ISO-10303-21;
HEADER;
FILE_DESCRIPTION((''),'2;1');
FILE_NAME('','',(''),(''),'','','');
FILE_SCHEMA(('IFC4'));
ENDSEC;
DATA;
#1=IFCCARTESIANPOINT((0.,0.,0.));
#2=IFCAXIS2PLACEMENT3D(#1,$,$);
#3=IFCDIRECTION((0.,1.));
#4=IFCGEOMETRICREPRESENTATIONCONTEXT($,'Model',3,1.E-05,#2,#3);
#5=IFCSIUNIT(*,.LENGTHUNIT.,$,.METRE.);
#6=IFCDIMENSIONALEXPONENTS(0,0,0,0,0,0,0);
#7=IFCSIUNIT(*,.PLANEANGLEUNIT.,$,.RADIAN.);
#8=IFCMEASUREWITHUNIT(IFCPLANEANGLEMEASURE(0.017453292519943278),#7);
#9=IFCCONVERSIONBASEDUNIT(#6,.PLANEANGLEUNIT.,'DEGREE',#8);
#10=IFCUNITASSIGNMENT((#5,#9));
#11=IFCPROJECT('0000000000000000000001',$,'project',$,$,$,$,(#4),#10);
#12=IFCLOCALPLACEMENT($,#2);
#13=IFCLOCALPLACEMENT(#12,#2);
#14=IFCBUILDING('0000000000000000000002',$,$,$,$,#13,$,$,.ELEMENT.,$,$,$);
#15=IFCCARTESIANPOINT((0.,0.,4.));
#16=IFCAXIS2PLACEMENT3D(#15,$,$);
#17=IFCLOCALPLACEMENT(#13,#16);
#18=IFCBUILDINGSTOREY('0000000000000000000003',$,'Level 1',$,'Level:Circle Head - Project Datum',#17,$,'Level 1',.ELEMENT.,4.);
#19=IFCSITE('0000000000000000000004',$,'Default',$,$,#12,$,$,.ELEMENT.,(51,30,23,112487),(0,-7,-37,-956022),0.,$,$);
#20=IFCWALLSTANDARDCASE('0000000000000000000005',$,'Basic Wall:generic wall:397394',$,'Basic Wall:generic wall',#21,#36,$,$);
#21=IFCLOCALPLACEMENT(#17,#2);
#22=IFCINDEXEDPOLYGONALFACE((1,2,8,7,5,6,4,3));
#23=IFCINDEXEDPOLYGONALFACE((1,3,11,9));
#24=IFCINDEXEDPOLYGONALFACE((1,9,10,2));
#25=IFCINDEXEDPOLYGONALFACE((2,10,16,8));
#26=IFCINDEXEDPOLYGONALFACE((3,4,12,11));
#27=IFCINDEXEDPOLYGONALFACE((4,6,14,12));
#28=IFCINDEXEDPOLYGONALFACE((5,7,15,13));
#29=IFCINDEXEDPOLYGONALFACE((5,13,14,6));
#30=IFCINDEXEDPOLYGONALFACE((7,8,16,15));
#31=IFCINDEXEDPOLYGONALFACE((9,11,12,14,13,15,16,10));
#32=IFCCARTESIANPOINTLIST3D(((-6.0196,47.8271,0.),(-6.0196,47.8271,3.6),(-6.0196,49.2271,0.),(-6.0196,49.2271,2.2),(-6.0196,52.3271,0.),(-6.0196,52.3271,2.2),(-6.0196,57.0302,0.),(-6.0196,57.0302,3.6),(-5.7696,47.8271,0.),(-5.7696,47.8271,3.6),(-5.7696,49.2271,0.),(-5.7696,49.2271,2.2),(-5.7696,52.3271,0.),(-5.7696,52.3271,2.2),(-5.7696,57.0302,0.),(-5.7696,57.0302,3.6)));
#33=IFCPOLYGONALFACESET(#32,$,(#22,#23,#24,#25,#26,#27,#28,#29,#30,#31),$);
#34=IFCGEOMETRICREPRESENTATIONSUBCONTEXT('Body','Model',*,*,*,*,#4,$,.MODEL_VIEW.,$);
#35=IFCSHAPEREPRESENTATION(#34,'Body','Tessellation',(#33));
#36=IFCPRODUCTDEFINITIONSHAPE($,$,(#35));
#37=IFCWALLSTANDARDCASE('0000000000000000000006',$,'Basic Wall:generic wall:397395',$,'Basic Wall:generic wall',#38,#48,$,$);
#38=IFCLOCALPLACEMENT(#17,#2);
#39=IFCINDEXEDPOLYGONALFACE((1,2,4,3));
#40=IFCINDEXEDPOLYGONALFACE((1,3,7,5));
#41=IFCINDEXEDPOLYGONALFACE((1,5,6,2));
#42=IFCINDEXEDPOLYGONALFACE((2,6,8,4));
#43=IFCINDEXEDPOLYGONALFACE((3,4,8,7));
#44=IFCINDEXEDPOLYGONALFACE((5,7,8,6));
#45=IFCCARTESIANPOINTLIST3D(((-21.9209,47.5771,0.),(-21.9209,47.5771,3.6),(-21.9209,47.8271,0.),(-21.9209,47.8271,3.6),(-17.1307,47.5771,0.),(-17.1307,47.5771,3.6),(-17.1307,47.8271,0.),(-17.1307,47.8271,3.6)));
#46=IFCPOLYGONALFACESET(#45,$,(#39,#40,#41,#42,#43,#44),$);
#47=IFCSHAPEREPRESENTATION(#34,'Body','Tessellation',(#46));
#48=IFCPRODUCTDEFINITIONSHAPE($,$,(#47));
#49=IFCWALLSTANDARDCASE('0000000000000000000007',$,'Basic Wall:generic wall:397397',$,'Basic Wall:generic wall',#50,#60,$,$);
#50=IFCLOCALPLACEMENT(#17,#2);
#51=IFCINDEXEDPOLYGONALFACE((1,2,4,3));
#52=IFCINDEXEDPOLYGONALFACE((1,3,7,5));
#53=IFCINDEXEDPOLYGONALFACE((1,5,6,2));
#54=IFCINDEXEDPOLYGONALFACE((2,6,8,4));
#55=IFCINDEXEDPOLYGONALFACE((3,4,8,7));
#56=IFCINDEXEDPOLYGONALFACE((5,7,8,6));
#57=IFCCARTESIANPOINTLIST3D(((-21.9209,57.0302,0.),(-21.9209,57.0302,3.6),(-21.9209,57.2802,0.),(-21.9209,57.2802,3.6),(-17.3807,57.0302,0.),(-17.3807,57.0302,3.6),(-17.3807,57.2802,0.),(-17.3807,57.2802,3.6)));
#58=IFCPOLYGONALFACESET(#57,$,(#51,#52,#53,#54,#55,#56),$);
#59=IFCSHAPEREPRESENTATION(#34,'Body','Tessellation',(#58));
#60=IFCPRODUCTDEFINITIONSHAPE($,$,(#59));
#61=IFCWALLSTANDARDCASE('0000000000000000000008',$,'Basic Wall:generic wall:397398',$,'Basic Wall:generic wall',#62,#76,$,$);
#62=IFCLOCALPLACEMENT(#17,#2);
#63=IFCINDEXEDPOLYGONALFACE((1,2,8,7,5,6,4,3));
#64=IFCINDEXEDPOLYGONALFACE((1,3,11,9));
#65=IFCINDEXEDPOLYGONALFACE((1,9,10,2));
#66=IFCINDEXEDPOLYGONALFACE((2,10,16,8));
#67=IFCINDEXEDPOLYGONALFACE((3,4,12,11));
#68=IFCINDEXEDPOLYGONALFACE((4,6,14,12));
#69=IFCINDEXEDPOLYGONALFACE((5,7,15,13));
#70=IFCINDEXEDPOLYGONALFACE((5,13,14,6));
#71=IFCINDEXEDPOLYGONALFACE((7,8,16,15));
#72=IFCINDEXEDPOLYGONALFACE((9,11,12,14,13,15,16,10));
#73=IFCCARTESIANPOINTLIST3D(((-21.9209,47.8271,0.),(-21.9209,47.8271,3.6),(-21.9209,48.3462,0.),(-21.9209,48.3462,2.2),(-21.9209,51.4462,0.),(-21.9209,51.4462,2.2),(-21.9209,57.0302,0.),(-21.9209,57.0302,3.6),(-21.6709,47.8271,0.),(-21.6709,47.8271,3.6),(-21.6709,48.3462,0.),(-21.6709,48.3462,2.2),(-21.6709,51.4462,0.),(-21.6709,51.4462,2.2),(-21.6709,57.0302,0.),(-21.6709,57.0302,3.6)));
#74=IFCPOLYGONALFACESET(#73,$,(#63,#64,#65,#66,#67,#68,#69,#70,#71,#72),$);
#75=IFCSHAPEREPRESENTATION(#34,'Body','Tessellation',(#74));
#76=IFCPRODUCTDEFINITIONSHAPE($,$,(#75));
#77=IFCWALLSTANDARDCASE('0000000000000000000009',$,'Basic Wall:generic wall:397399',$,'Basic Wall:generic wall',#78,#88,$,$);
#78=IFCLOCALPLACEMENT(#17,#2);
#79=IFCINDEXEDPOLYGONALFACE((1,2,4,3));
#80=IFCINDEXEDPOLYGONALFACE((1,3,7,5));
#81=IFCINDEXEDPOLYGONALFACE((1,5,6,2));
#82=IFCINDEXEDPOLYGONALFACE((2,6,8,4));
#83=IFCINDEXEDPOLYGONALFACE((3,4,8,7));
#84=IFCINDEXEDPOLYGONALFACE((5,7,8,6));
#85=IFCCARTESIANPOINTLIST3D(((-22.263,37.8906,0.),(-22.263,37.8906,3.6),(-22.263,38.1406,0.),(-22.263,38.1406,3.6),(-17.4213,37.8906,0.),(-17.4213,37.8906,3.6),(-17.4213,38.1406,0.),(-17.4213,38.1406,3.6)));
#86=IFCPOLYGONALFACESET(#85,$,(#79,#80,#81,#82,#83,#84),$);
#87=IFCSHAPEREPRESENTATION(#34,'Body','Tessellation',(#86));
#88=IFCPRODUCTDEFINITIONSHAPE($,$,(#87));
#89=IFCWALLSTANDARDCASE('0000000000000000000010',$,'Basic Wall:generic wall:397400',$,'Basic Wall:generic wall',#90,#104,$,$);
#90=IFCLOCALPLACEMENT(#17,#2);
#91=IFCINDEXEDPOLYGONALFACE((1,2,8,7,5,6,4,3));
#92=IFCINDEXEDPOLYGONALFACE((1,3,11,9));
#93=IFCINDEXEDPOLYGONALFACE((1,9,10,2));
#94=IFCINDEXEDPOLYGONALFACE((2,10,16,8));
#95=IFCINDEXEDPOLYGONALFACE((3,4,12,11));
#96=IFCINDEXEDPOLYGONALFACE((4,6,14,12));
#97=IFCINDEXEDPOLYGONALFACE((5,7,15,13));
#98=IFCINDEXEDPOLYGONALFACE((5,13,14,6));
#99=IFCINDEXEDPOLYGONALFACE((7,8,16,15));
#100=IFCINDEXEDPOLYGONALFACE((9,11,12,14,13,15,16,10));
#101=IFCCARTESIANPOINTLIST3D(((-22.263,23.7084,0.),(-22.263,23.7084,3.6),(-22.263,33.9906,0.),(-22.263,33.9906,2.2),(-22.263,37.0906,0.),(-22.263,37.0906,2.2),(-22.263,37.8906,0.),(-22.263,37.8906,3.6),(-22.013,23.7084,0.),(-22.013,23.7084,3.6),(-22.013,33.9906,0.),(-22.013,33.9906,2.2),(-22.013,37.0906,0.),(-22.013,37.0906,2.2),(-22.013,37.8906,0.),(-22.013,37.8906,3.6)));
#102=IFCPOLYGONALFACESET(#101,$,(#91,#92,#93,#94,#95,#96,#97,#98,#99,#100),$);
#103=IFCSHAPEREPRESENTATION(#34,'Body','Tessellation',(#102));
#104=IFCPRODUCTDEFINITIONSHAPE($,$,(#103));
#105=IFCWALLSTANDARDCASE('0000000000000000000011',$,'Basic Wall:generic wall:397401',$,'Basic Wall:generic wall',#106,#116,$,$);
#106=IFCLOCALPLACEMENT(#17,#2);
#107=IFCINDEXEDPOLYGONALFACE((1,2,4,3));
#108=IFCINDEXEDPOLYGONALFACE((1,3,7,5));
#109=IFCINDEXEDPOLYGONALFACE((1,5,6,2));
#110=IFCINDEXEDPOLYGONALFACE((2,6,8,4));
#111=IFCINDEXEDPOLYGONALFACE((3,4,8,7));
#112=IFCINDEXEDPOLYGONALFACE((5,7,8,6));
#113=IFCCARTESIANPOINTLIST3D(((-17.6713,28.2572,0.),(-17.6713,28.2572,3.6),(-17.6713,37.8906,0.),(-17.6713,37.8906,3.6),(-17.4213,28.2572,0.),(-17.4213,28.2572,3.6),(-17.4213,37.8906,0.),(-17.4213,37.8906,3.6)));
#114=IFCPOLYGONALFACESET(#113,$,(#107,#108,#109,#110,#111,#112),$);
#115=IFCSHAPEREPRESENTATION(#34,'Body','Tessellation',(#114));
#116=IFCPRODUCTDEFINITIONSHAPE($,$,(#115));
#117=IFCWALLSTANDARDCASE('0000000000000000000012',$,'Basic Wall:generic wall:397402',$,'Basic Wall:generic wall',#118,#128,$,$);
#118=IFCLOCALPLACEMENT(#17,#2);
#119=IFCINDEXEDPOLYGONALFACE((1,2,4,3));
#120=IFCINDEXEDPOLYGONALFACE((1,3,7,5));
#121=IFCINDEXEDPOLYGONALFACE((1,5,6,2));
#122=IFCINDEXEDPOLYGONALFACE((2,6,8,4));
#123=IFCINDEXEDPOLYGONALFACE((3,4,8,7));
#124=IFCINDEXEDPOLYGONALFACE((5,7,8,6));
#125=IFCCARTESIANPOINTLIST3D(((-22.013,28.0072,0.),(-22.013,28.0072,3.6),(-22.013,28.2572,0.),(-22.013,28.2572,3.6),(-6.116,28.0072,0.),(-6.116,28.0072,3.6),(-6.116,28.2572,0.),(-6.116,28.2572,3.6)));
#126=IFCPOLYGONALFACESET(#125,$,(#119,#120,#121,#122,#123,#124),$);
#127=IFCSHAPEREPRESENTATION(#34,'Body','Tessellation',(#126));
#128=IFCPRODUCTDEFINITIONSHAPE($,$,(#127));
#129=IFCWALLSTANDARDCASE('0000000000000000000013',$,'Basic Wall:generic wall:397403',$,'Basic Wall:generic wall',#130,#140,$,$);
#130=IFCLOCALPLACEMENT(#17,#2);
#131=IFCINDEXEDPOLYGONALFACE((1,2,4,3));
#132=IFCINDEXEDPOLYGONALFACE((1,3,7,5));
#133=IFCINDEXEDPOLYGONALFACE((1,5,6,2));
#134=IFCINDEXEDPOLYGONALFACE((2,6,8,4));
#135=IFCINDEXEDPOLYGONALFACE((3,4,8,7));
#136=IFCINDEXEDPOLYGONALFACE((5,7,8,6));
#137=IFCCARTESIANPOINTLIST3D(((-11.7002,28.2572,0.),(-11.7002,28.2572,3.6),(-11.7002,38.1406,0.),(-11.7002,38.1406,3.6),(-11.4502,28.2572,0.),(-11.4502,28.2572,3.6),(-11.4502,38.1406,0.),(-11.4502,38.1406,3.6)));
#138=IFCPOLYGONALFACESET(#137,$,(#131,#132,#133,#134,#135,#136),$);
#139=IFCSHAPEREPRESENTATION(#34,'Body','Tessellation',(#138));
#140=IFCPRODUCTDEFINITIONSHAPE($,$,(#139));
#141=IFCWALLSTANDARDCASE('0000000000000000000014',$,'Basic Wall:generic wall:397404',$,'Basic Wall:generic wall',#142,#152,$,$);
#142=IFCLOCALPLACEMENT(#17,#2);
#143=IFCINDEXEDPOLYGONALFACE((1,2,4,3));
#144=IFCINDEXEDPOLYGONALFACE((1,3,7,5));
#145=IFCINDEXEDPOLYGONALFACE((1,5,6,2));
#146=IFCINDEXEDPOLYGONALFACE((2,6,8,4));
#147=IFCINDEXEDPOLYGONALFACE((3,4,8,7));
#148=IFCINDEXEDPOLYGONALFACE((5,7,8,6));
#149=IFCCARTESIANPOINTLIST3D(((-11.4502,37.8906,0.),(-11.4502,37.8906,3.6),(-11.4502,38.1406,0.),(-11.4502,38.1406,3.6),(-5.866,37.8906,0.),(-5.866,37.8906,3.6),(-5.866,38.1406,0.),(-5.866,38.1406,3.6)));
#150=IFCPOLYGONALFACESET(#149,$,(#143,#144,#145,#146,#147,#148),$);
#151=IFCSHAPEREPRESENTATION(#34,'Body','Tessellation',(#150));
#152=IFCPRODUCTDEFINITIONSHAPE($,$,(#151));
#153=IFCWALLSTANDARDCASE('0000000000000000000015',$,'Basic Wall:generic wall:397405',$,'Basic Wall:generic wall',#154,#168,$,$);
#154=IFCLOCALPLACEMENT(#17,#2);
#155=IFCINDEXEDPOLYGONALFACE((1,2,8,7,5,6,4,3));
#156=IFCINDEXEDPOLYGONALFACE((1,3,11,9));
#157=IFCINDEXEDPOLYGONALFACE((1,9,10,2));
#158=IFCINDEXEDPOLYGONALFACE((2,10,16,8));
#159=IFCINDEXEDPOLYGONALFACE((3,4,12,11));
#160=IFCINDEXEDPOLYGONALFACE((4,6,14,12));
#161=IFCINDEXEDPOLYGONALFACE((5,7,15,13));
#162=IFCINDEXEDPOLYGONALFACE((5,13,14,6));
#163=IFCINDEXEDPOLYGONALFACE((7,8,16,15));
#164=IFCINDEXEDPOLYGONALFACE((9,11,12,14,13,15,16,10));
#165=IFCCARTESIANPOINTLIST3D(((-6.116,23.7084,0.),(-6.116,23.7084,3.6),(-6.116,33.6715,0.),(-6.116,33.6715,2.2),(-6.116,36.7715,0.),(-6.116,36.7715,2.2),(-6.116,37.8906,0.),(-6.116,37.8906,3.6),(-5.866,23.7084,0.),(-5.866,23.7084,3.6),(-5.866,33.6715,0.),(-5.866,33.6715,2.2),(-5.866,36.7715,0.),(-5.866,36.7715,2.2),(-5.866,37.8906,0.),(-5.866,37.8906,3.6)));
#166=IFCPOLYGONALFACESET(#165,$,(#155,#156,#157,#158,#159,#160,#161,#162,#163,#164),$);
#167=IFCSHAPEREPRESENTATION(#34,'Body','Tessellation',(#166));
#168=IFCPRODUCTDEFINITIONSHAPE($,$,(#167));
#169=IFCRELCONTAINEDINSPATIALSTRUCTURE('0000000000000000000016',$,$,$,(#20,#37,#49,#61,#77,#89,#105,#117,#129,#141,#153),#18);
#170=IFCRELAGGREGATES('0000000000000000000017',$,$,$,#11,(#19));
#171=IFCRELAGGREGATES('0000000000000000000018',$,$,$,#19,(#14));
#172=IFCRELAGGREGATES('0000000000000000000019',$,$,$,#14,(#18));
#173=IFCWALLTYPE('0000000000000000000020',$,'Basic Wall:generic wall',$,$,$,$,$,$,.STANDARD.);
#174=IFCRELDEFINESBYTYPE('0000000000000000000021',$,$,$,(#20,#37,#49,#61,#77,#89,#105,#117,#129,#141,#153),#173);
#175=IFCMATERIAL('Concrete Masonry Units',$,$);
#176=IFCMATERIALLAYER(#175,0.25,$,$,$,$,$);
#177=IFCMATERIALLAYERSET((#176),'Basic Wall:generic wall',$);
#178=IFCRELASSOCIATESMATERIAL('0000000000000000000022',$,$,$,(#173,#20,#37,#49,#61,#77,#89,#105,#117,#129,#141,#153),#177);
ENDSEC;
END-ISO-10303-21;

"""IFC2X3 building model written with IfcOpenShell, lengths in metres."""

from ifc_helpers import new_model, entity, si_unit, converted_unit, direction, frame, frame_2d, origin, place, context, subcontext, project, spatial, rectangle, extrude, material, layer, layer_set, layer_usage, type_object, element, save


model = new_model("IFC2X3")

# Units and contexts
model_context = context("Model", 3, precision=1e-05, world=origin(), true_north=direction((0.0, 1.0)))
body_context = subcontext(model_context, "Body", "Model", "MODEL_VIEW")
ifc_project = project(units=[si_unit("LENGTHUNIT", "METRE"), converted_unit("PLANEANGLEUNIT", "DEGREE", entity("IfcPlaneAngleMeasure", 0.017453292519943278), si_unit("PLANEANGLEUNIT", "RADIAN"), dimensions=[0, 0, 0, 0, 0, 0, 0])], contexts=[model_context])

# Site, building, storey
site_placement = place(None, origin())
site = spatial("IfcSite", under=ifc_project, at=site_placement, Name="Default", CompositionType="ELEMENT", RefLatitude=(51, 30, 23, 112487), RefLongitude=(0, -7, -37, -956022), RefElevation=0.0)
building_placement = place(site_placement, origin())
building = spatial("IfcBuilding", under=site, at=building_placement, CompositionType="ELEMENT")
storey_placement = place(building_placement, frame((0.0, 0.0, 4.0)))
storey = spatial("IfcBuildingStorey", under=building, at=storey_placement, Name="Level 1", ObjectType="Level:Circle Head - Project Datum", LongName="Level 1", CompositionType="ELEMENT", Elevation=4.0)

# Shared definitions
ifc_material = material(Name="Concrete Masonry Units")
ifc_layer = layer(ifc_material, 0.25)
ifc_layer_set = layer_set([ifc_layer], Name="Basic Wall:generic wall")
wall_type = type_object("IfcWallType", Name="Basic Wall:generic wall", PredefinedType="STANDARD", material=ifc_layer_set)

# Wall, opening
ifc_layer_usage_1 = layer_usage(ifc_layer_set, "AXIS2", "NEGATIVE", 0.125)
wall_1_placement = place(storey_placement, frame((-5.8946, 57.0302, 0.0), z_axis=(0.0, 0.0, 1.0), x_axis=(0.0, -1.0, 0.0)))
wall_1 = element("IfcWallStandardCase", 1, at=wall_1_placement, inside=storey, type_object=wall_type, material=ifc_layer_usage_1, Name="Basic Wall:generic wall:397394", ObjectType="Basic Wall:generic wall", context=body_context, shape_type="SweptSolid", body=[
    extrude(rectangle(XDim=9.2031, YDim=0.25, at=frame_2d((4.6015, 0.0), x_axis=(1.0, 0.0))), origin(), (0.0, 0.0, 1.0), 3.6),
])
opening_1_placement = place(wall_1_placement, frame((7.8031, 0.125, 0.0)))
element("IfcOpeningElement", 2, at=opening_1_placement, cuts=wall_1, ObjectType="Opening", context=body_context, shape_type="SweptSolid", body=[
    extrude(rectangle(XDim=2.2, YDim=3.1, at=frame_2d((1.1, 1.55), x_axis=(1.0, 0.0))), frame((0.0, 0.0, 0.0), z_axis=(0.0, -1.0, 0.0), x_axis=(0.0, 0.0, 1.0)), (0.0, 0.0, 1.0), 0.25),
])

# Walls
ifc_layer_usage_2 = layer_usage(ifc_layer_set, "AXIS2", "NEGATIVE", 0.125)
wall_2_placement = place(storey_placement, frame((-17.1307, 47.7021, 0.0), z_axis=(0.0, 0.0, 1.0), x_axis=(-1.0, 0.0, 0.0)))
element("IfcWallStandardCase", 3, at=wall_2_placement, inside=storey, type_object=wall_type, material=ifc_layer_usage_2, Name="Basic Wall:generic wall:397395", ObjectType="Basic Wall:generic wall", context=body_context, shape_type="SweptSolid", body=[
    extrude(rectangle(XDim=4.7901, YDim=0.25, at=frame_2d((2.3951, 0.0), x_axis=(-1.0, 0.0))), origin(), (0.0, 0.0, 1.0), 3.6),
])
ifc_layer_usage_3 = layer_usage(ifc_layer_set, "AXIS2", "NEGATIVE", 0.125)
wall_3_placement = place(storey_placement, frame((-21.9209, 57.1552, 0.0)))
element("IfcWallStandardCase", 4, at=wall_3_placement, inside=storey, type_object=wall_type, material=ifc_layer_usage_3, Name="Basic Wall:generic wall:397397", ObjectType="Basic Wall:generic wall", context=body_context, shape_type="SweptSolid", body=[
    extrude(rectangle(XDim=4.5401, YDim=0.25, at=frame_2d((2.2701, 0.0), x_axis=(-1.0, 0.0))), origin(), (0.0, 0.0, 1.0), 3.6),
])

# Wall, opening
ifc_layer_usage_4 = layer_usage(ifc_layer_set, "AXIS2", "NEGATIVE", 0.125)
wall_4_placement = place(storey_placement, frame((-21.7959, 47.8271, 0.0), z_axis=(0.0, 0.0, 1.0), x_axis=(0.0, 1.0, 0.0)))
wall_4 = element("IfcWallStandardCase", 5, at=wall_4_placement, inside=storey, type_object=wall_type, material=ifc_layer_usage_4, Name="Basic Wall:generic wall:397398", ObjectType="Basic Wall:generic wall", context=body_context, shape_type="SweptSolid", body=[
    extrude(rectangle(XDim=9.2031, YDim=0.25, at=frame_2d((4.6015, 0.0), x_axis=(-1.0, 0.0))), origin(), (0.0, 0.0, 1.0), 3.6),
])
opening_2_placement = place(wall_4_placement, frame((3.619, 0.125, 0.0)))
element("IfcOpeningElement", 6, at=opening_2_placement, cuts=wall_4, ObjectType="Opening", context=body_context, shape_type="SweptSolid", body=[
    extrude(rectangle(XDim=2.2, YDim=3.1, at=frame_2d((1.1, 1.55), x_axis=(1.0, 0.0))), frame((0.0, 0.0, 0.0), z_axis=(0.0, -1.0, 0.0), x_axis=(0.0, 0.0, 1.0)), (0.0, 0.0, 1.0), 0.25),
])

# Wall
ifc_layer_usage_5 = layer_usage(ifc_layer_set, "AXIS2", "NEGATIVE", 0.125)
wall_5_placement = place(storey_placement, frame((-22.263, 38.0156, 0.0)))
element("IfcWallStandardCase", 7, at=wall_5_placement, inside=storey, type_object=wall_type, material=ifc_layer_usage_5, Name="Basic Wall:generic wall:397399", ObjectType="Basic Wall:generic wall", context=body_context, shape_type="SweptSolid", body=[
    extrude(rectangle(XDim=4.8417, YDim=0.25, at=frame_2d((2.4208, 0.0), x_axis=(-1.0, 0.0))), origin(), (0.0, 0.0, 1.0), 3.6),
])

# Wall, opening
ifc_layer_usage_6 = layer_usage(ifc_layer_set, "AXIS2", "NEGATIVE", 0.125)
wall_6_placement = place(storey_placement, frame((-22.138, 23.7084, 0.0), z_axis=(0.0, 0.0, 1.0), x_axis=(0.0, 1.0, 0.0)))
wall_6 = element("IfcWallStandardCase", 8, at=wall_6_placement, inside=storey, type_object=wall_type, material=ifc_layer_usage_6, Name="Basic Wall:generic wall:397400", ObjectType="Basic Wall:generic wall", context=body_context, shape_type="SweptSolid", body=[
    extrude(rectangle(XDim=14.1822, YDim=0.25, at=frame_2d((7.0911, 0.0), x_axis=(-1.0, 0.0))), origin(), (0.0, 0.0, 1.0), 3.6),
])
opening_3_placement = place(wall_6_placement, frame((13.3822, 0.125, 0.0)))
element("IfcOpeningElement", 9, at=opening_3_placement, cuts=wall_6, ObjectType="Opening", context=body_context, shape_type="SweptSolid", body=[
    extrude(rectangle(XDim=2.2, YDim=3.1, at=frame_2d((1.1, 1.55), x_axis=(1.0, 0.0))), frame((0.0, 0.0, 0.0), z_axis=(0.0, -1.0, 0.0), x_axis=(0.0, 0.0, 1.0)), (0.0, 0.0, 1.0), 0.25),
])

# Walls
ifc_layer_usage_7 = layer_usage(ifc_layer_set, "AXIS2", "NEGATIVE", 0.125)
wall_7_placement = place(storey_placement, frame((-17.5463, 37.8906, 0.0), z_axis=(0.0, 0.0, 1.0), x_axis=(0.0, -1.0, 0.0)))
element("IfcWallStandardCase", 10, at=wall_7_placement, inside=storey, type_object=wall_type, material=ifc_layer_usage_7, Name="Basic Wall:generic wall:397401", ObjectType="Basic Wall:generic wall", context=body_context, shape_type="SweptSolid", body=[
    extrude(rectangle(XDim=9.6334, YDim=0.25, at=frame_2d((4.8167, 0.0), x_axis=(-1.0, 0.0))), origin(), (0.0, 0.0, 1.0), 3.6),
])
ifc_layer_usage_8 = layer_usage(ifc_layer_set, "AXIS2", "NEGATIVE", 0.125)
wall_8_placement = place(storey_placement, frame((-6.116, 28.1322, 0.0), z_axis=(0.0, 0.0, 1.0), x_axis=(-1.0, 0.0, 0.0)))
element("IfcWallStandardCase", 11, at=wall_8_placement, inside=storey, type_object=wall_type, material=ifc_layer_usage_8, Name="Basic Wall:generic wall:397402", ObjectType="Basic Wall:generic wall", context=body_context, shape_type="SweptSolid", body=[
    extrude(rectangle(XDim=15.8969, YDim=0.25, at=frame_2d((7.9485, 0.0), x_axis=(-1.0, 0.0))), origin(), (0.0, 0.0, 1.0), 3.6),
])
ifc_layer_usage_9 = layer_usage(ifc_layer_set, "AXIS2", "NEGATIVE", 0.125)
wall_9_placement = place(storey_placement, frame((-11.5752, 28.2572, 0.0), z_axis=(0.0, 0.0, 1.0), x_axis=(0.0, 1.0, 0.0)))
element("IfcWallStandardCase", 12, at=wall_9_placement, inside=storey, type_object=wall_type, material=ifc_layer_usage_9, Name="Basic Wall:generic wall:397403", ObjectType="Basic Wall:generic wall", context=body_context, shape_type="SweptSolid", body=[
    extrude(rectangle(XDim=9.8834, YDim=0.25, at=frame_2d((4.9417, 0.0), x_axis=(-1.0, 0.0))), origin(), (0.0, 0.0, 1.0), 3.6),
])
ifc_layer_usage_10 = layer_usage(ifc_layer_set, "AXIS2", "NEGATIVE", 0.125)
wall_10_placement = place(storey_placement, frame((-11.4502, 38.0156, 0.0)))
element("IfcWallStandardCase", 13, at=wall_10_placement, inside=storey, type_object=wall_type, material=ifc_layer_usage_10, Name="Basic Wall:generic wall:397404", ObjectType="Basic Wall:generic wall", context=body_context, shape_type="SweptSolid", body=[
    extrude(rectangle(XDim=5.5841, YDim=0.25, at=frame_2d((2.7921, 0.0), x_axis=(-1.0, 0.0))), origin(), (0.0, 0.0, 1.0), 3.6),
])

# Wall, opening
ifc_layer_usage_11 = layer_usage(ifc_layer_set, "AXIS2", "NEGATIVE", 0.125)
wall_11_placement = place(storey_placement, frame((-5.991, 37.8906, 0.0), z_axis=(0.0, 0.0, 1.0), x_axis=(0.0, -1.0, 0.0)))
wall_11 = element("IfcWallStandardCase", 14, at=wall_11_placement, inside=storey, type_object=wall_type, material=ifc_layer_usage_11, Name="Basic Wall:generic wall:397405", ObjectType="Basic Wall:generic wall", context=body_context, shape_type="SweptSolid", body=[
    extrude(rectangle(XDim=14.1822, YDim=0.25, at=frame_2d((7.0911, 0.0), x_axis=(1.0, 0.0))), origin(), (0.0, 0.0, 1.0), 3.6),
])
opening_4_placement = place(wall_11_placement, frame((4.219, 0.125, 0.0)))
element("IfcOpeningElement", 15, at=opening_4_placement, cuts=wall_11, ObjectType="Opening", context=body_context, shape_type="SweptSolid", body=[
    extrude(rectangle(XDim=2.2, YDim=3.1, at=frame_2d((1.1, 1.55), x_axis=(1.0, 0.0))), frame((0.0, 0.0, 0.0), z_axis=(0.0, -1.0, 0.0), x_axis=(0.0, 0.0, 1.0)), (0.0, 0.0, 1.0), 0.25),
])

save(model, "model.ifc")
